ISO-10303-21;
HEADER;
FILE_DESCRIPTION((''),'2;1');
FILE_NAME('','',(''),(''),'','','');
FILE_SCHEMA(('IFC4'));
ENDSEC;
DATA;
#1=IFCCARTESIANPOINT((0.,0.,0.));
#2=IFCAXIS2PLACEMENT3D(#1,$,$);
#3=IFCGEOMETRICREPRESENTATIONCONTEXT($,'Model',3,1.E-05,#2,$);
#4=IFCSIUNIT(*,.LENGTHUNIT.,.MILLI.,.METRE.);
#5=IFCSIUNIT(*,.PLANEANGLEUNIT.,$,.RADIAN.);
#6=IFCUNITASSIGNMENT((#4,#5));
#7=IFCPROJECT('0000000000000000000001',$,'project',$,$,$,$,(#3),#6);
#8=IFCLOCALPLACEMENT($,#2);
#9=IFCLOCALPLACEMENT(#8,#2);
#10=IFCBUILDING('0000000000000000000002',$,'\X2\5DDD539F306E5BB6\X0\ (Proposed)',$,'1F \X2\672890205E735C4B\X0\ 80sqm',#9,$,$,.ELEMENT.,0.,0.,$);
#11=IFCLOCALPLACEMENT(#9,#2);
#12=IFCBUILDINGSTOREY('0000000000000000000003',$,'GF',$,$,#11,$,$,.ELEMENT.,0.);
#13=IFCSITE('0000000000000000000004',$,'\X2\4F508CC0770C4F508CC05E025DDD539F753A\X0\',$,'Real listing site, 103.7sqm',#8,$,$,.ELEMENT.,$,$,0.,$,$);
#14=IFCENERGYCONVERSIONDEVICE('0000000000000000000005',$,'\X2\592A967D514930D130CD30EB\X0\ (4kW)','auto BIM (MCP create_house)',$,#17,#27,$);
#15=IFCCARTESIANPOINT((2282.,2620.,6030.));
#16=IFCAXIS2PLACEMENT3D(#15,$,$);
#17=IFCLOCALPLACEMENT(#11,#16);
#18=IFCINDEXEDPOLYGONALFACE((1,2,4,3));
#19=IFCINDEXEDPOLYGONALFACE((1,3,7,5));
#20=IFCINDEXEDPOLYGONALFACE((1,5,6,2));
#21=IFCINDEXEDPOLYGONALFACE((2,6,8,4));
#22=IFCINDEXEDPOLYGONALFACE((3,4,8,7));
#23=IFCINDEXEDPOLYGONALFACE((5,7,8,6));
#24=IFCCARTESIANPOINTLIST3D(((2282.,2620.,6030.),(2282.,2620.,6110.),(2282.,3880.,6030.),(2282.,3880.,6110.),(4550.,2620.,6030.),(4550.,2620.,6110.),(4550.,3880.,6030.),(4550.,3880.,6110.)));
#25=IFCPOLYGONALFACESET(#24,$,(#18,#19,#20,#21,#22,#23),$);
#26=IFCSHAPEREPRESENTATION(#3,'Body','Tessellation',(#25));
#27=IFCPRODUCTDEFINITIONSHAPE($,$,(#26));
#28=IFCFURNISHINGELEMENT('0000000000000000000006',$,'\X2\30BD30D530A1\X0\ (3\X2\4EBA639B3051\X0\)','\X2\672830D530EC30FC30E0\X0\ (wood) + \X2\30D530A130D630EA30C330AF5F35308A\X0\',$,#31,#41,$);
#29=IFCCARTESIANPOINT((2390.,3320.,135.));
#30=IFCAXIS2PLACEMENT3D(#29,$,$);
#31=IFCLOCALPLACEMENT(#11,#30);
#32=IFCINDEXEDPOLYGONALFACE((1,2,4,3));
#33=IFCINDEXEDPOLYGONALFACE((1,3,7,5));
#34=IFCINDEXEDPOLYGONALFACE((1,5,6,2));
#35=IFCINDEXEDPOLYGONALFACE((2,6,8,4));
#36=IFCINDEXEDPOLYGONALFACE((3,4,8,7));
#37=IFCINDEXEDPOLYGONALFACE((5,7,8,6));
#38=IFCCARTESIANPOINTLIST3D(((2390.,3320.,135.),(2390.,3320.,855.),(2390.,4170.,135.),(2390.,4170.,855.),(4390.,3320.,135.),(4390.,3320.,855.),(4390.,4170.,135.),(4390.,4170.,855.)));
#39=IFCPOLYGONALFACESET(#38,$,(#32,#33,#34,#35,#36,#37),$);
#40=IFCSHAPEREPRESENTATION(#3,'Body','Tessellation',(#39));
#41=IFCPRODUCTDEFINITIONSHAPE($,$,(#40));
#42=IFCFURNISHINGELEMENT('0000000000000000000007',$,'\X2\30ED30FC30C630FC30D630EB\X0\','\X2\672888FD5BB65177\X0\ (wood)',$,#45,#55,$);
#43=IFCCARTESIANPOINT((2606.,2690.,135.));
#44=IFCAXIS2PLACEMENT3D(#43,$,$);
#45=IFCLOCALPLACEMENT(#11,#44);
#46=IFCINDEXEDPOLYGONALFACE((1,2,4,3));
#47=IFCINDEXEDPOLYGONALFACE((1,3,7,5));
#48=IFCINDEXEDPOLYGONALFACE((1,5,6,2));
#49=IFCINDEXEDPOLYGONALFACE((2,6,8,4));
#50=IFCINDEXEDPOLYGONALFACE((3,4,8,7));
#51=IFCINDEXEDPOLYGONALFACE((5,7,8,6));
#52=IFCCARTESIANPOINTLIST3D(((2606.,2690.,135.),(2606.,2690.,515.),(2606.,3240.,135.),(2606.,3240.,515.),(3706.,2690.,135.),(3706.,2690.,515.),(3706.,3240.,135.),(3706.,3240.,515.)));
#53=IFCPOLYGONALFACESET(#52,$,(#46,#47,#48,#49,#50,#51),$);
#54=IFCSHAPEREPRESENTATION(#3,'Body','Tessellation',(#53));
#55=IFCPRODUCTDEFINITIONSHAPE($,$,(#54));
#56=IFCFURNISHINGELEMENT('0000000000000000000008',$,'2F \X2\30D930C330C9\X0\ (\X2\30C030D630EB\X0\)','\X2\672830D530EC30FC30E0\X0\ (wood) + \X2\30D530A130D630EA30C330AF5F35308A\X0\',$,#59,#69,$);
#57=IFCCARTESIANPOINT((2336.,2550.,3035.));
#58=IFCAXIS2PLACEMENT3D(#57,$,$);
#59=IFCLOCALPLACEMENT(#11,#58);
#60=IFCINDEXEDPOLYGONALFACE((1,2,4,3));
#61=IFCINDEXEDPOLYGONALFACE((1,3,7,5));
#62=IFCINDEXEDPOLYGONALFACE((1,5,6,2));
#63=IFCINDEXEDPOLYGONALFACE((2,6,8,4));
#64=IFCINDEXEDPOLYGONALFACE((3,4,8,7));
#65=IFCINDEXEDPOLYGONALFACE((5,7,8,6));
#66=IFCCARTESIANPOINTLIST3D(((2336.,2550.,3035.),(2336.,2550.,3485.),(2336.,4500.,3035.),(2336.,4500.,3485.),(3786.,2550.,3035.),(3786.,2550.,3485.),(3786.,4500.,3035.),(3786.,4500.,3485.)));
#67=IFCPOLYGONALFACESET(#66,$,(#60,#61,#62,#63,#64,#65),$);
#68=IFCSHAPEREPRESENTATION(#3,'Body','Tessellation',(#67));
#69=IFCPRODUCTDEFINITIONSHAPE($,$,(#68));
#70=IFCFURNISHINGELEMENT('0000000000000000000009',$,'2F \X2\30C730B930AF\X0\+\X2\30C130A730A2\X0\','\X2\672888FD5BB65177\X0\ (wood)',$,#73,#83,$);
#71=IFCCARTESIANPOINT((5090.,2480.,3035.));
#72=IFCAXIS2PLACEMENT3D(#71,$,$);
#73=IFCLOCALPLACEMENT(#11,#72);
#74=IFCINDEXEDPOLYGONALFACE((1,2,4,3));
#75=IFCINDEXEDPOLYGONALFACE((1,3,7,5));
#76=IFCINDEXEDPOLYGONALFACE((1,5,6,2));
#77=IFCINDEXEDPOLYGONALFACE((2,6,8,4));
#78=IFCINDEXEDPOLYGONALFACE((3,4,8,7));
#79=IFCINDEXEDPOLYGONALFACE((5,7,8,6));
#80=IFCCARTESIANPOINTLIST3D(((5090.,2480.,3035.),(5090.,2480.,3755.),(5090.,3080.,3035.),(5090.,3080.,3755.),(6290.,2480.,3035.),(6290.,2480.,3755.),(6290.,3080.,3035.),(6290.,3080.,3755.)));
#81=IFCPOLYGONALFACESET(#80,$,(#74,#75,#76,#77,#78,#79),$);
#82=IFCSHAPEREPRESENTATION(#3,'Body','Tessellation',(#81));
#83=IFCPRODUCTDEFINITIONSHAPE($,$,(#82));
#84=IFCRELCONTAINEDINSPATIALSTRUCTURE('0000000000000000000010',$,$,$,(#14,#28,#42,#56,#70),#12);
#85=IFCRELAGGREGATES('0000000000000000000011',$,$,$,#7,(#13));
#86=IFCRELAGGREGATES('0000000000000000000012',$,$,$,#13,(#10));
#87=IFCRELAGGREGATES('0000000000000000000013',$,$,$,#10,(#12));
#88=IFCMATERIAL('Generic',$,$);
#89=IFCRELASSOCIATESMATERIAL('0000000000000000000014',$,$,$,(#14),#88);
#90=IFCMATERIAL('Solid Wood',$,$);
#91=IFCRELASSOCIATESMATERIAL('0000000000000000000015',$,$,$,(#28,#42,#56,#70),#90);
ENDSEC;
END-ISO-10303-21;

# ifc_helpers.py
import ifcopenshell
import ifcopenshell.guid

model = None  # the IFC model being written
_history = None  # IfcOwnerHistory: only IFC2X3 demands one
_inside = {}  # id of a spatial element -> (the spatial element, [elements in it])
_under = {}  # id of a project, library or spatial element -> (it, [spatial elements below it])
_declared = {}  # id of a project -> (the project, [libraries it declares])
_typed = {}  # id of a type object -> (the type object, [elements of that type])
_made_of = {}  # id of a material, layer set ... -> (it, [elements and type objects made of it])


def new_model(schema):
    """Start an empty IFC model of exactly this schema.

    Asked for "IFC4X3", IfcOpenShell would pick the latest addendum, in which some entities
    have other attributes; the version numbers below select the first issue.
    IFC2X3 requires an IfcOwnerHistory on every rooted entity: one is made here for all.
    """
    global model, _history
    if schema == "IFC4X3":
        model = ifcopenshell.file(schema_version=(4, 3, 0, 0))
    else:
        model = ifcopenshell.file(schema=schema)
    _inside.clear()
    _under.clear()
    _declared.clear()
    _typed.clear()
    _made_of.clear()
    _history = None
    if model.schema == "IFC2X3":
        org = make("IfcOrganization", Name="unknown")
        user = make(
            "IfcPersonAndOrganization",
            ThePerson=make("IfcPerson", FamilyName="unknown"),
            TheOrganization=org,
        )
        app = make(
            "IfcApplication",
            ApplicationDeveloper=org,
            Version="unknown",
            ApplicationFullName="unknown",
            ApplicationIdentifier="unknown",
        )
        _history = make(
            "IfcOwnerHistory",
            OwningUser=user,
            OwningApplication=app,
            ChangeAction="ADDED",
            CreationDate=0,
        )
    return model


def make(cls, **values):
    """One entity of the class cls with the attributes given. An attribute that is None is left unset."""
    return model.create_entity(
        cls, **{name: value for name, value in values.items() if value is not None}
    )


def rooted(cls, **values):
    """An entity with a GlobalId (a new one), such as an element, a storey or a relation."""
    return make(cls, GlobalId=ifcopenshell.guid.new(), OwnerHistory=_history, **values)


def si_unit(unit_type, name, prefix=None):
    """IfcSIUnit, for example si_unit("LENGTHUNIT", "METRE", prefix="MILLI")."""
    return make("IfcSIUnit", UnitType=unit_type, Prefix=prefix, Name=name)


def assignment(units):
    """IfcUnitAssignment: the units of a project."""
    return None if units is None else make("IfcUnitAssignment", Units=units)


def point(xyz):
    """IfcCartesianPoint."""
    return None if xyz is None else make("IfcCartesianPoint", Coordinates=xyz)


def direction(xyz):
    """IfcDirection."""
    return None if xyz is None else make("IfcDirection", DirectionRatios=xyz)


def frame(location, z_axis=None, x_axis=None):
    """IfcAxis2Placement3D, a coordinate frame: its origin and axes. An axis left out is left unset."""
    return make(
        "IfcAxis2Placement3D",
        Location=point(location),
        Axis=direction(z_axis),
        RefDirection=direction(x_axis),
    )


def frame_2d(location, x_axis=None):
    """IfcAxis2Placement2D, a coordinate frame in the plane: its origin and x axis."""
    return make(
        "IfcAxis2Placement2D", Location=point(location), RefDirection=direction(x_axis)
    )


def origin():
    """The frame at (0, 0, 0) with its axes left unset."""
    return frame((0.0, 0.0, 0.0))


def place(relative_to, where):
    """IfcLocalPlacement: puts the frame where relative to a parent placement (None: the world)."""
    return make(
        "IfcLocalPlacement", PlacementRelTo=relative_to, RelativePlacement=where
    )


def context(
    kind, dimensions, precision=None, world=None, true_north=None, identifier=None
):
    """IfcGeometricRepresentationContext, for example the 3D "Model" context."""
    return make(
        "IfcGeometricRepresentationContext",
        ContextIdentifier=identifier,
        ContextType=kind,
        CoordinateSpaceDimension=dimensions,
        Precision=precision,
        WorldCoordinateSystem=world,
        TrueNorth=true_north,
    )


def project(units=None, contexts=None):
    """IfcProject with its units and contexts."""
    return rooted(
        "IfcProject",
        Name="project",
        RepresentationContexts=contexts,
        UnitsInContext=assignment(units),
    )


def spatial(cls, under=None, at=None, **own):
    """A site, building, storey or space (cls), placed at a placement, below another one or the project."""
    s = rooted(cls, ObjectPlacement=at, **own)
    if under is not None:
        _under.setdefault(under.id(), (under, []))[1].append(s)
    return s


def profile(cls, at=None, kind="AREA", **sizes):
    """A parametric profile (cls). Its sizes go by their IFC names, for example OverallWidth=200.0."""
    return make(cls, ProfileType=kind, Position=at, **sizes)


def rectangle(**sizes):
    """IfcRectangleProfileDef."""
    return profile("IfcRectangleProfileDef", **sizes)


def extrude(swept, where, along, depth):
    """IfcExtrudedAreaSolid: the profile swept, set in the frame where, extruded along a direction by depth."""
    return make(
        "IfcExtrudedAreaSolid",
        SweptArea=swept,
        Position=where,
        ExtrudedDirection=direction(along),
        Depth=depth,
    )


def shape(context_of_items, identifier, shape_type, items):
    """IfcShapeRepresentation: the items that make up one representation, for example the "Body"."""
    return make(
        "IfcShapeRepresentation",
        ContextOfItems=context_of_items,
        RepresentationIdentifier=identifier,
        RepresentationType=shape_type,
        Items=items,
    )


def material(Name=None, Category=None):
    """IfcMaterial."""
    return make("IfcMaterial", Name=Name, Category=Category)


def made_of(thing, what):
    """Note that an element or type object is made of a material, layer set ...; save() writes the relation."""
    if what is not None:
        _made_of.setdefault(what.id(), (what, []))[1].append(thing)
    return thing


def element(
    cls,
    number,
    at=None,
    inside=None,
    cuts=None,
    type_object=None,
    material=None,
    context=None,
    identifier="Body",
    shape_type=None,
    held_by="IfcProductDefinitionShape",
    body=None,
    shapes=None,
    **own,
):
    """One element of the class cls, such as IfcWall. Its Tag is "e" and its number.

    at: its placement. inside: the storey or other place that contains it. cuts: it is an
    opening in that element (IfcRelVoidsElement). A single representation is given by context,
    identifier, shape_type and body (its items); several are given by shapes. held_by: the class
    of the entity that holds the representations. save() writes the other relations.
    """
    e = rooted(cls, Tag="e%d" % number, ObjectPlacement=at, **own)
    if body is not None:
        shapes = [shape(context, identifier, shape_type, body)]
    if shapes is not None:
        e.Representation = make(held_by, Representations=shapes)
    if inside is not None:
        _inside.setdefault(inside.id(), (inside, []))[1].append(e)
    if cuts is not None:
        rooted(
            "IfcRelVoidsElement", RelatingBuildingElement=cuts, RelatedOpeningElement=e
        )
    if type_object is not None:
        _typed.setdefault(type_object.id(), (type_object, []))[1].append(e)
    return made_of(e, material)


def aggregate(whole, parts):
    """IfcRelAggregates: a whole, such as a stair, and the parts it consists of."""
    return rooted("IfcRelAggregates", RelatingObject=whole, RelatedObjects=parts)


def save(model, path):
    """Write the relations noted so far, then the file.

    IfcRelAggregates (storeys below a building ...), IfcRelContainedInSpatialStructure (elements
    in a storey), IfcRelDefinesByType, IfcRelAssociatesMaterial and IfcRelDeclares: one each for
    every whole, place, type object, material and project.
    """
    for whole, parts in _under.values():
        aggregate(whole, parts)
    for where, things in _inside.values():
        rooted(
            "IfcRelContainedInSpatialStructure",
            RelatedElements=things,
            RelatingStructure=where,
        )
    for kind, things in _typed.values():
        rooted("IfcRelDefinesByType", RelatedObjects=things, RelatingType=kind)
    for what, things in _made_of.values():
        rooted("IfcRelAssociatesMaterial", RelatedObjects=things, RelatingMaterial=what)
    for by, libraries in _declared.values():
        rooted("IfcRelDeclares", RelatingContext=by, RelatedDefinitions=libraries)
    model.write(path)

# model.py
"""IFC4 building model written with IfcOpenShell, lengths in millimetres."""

from ifc_helpers import new_model, si_unit, frame, frame_2d, origin, place, context, project, spatial, rectangle, extrude, material, element, save


model = new_model("IFC4")

# Units and contexts
model_context = context("Model", 3, precision=1e-05, world=origin())
ifc_project = project(units=[si_unit("LENGTHUNIT", "METRE", prefix="MILLI"), si_unit("PLANEANGLEUNIT", "RADIAN")], contexts=[model_context])

# Site, building, storey
site_placement = place(None, origin())
site = spatial("IfcSite", under=ifc_project, at=site_placement, Name="佐賀県佐賀市川原町", ObjectType="Real listing site, 103.7sqm", CompositionType="ELEMENT", RefElevation=0.0)
building_placement = place(site_placement, origin())
building = spatial("IfcBuilding", under=site, at=building_placement, Name="川原の家 (Proposed)", ObjectType="1F 木造平屋 80sqm", CompositionType="ELEMENT", ElevationOfRefHeight=0.0, ElevationOfTerrain=0.0)
storey_placement = place(building_placement, origin())
storey = spatial("IfcBuildingStorey", under=building, at=storey_placement, Name="GF", CompositionType="ELEMENT", Elevation=0.0)

# Shared definitions
ifc_material_1 = material(Name="Solid Wood")

# Shared definitions
ifc_material_2 = material(Name="Generic")

# Energy conversion device
energy_conversion_device_placement = place(storey_placement, frame((2282.0, 2620.0, 6030.0)))
element("IfcEnergyConversionDevice", 1, at=energy_conversion_device_placement, inside=storey, material=ifc_material_2, Name="太陽光パネル (4kW)", Description="auto BIM (MCP create_house)", context=model_context, shape_type="SweptSolid", body=[
    extrude(rectangle(XDim=2268.0, YDim=1260.0, at=frame_2d((1134.0, 630.0))), frame((2282.0, 2620.0, 6030.0)), (0.0, 0.0, 1.0), 80.0),
])

# Furnishing elements
furnishing_1_placement = place(storey_placement, frame((2390.0, 3320.0, 135.0)))
element("IfcFurnishingElement", 2, at=furnishing_1_placement, inside=storey, material=ifc_material_1, Name="ソファ (3人掛け)", Description="木フレーム (wood) + ファブリック張り", context=model_context, shape_type="SweptSolid", body=[
    extrude(rectangle(XDim=2000.0, YDim=850.0, at=frame_2d((1000.0, 425.0))), frame((2390.0, 3320.0, 135.0)), (0.0, 0.0, 1.0), 720.0),
])
furnishing_2_placement = place(storey_placement, frame((2606.0, 2690.0, 135.0)))
element("IfcFurnishingElement", 3, at=furnishing_2_placement, inside=storey, material=ifc_material_1, Name="ローテーブル", Description="木製家具 (wood)", context=model_context, shape_type="SweptSolid", body=[
    extrude(rectangle(XDim=1100.0, YDim=550.0, at=frame_2d((550.0, 275.0))), frame((2606.0, 2690.0, 135.0)), (0.0, 0.0, 1.0), 380.0),
])
furnishing_3_placement = place(storey_placement, frame((2336.0, 2550.0, 3035.0)))
element("IfcFurnishingElement", 4, at=furnishing_3_placement, inside=storey, material=ifc_material_1, Name="2F ベッド (ダブル)", Description="木フレーム (wood) + ファブリック張り", context=model_context, shape_type="SweptSolid", body=[
    extrude(rectangle(XDim=1450.0, YDim=1950.0, at=frame_2d((725.0, 975.0))), frame((2336.0, 2550.0, 3035.0)), (0.0, 0.0, 1.0), 450.0),
])
furnishing_4_placement = place(storey_placement, frame((5090.0, 2480.0, 3035.0)))
element("IfcFurnishingElement", 5, at=furnishing_4_placement, inside=storey, material=ifc_material_1, Name="2F デスク+チェア", Description="木製家具 (wood)", context=model_context, shape_type="SweptSolid", body=[
    extrude(rectangle(XDim=1200.0, YDim=600.0, at=frame_2d((600.0, 300.0))), frame((5090.0, 2480.0, 3035.0)), (0.0, 0.0, 1.0), 720.0),
])

save(model, "model.ifc")
